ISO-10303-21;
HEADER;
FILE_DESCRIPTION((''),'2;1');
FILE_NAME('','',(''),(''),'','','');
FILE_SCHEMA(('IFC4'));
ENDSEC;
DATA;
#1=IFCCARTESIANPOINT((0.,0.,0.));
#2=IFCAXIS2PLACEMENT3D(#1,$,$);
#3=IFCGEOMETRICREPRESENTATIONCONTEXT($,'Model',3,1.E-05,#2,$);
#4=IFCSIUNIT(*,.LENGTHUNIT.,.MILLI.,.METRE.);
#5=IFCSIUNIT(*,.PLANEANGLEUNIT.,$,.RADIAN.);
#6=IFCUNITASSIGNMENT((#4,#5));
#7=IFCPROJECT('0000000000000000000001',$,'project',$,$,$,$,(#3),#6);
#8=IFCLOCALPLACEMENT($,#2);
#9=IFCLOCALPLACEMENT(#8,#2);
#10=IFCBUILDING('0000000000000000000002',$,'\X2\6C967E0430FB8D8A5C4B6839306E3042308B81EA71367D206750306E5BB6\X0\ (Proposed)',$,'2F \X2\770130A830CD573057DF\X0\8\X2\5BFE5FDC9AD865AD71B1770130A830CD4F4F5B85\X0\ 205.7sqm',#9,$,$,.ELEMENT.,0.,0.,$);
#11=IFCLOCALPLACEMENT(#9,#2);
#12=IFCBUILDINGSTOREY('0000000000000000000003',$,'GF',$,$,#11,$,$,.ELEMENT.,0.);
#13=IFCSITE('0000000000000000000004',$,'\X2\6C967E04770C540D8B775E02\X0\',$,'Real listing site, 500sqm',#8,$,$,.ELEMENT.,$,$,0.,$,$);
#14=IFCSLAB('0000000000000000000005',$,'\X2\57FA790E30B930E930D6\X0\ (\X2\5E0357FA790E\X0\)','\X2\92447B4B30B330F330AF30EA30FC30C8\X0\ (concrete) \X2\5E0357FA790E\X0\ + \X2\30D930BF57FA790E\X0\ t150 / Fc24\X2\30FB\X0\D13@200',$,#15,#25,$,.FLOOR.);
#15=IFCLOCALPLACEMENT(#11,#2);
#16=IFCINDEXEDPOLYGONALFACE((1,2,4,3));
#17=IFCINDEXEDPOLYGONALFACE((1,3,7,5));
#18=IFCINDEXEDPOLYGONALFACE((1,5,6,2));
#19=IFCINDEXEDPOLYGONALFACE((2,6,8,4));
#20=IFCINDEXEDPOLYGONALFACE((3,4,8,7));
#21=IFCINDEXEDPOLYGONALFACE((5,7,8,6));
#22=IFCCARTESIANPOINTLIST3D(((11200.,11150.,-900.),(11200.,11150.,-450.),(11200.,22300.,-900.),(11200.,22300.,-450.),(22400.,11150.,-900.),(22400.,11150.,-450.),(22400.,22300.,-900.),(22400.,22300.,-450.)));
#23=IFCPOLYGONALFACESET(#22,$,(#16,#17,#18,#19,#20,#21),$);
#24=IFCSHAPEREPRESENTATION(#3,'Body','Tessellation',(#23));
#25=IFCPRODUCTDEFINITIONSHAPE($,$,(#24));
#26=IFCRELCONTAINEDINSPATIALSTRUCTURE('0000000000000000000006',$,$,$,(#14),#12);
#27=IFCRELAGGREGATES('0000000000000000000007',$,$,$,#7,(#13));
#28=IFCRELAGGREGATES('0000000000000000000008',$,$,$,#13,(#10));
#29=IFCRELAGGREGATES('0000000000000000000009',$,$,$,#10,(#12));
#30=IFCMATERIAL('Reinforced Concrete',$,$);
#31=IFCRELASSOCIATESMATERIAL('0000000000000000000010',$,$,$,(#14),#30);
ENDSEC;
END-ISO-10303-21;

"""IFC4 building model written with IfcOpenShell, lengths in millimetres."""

from ifc_helpers import new_model, si_unit, frame, frame_2d, origin, place, context, project, spatial, rectangle, extrude, material, element, save


model = new_model("IFC4")

# Units and contexts
model_context = context("Model", 3, precision=1e-05, world=origin())
ifc_project = project(units=[si_unit("LENGTHUNIT", "METRE", prefix="MILLI"), si_unit("PLANEANGLEUNIT", "RADIAN")], contexts=[model_context])

# Site, building, storey
site_placement = place(None, origin())
site = spatial("IfcSite", under=ifc_project, at=site_placement, Name="沖縄県名護市", ObjectType="Real listing site, 500sqm", CompositionType="ELEMENT", RefElevation=0.0)
building_placement = place(site_placement, origin())
building = spatial("IfcBuilding", under=site, at=building_placement, Name="沖縄・越屋根のある自然素材の家 (Proposed)", ObjectType="2F 省エネ地域8対応高断熱省エネ住宅 205.7sqm", CompositionType="ELEMENT", ElevationOfRefHeight=0.0, ElevationOfTerrain=0.0)
storey_placement = place(building_placement, origin())
storey = spatial("IfcBuildingStorey", under=building, at=storey_placement, Name="GF", CompositionType="ELEMENT", Elevation=0.0)

# Slab
ifc_material_1 = material(Name="Reinforced Concrete")
slab_1_placement = place(storey_placement, frame((5600.0, 5575.0, -450.0)))
element("IfcSlab", 1, at=slab_1_placement, inside=storey, material=ifc_material_1, Name="基礎スラブ (布基礎)", Description="鉄筋コンクリート (concrete) 布基礎 + ベタ基礎 t150 / Fc24・D13@200", PredefinedType="FLOOR", context=model_context, shape_type="SweptSolid", body=[
    extrude(rectangle(XDim=11200.0, YDim=11150.0, at=frame_2d((5600.0, 5575.0))), frame((5600.0, 5575.0, -450.0)), (0.0, 0.0, 1.0), 450.0),
])

save(model, "model.ifc")
